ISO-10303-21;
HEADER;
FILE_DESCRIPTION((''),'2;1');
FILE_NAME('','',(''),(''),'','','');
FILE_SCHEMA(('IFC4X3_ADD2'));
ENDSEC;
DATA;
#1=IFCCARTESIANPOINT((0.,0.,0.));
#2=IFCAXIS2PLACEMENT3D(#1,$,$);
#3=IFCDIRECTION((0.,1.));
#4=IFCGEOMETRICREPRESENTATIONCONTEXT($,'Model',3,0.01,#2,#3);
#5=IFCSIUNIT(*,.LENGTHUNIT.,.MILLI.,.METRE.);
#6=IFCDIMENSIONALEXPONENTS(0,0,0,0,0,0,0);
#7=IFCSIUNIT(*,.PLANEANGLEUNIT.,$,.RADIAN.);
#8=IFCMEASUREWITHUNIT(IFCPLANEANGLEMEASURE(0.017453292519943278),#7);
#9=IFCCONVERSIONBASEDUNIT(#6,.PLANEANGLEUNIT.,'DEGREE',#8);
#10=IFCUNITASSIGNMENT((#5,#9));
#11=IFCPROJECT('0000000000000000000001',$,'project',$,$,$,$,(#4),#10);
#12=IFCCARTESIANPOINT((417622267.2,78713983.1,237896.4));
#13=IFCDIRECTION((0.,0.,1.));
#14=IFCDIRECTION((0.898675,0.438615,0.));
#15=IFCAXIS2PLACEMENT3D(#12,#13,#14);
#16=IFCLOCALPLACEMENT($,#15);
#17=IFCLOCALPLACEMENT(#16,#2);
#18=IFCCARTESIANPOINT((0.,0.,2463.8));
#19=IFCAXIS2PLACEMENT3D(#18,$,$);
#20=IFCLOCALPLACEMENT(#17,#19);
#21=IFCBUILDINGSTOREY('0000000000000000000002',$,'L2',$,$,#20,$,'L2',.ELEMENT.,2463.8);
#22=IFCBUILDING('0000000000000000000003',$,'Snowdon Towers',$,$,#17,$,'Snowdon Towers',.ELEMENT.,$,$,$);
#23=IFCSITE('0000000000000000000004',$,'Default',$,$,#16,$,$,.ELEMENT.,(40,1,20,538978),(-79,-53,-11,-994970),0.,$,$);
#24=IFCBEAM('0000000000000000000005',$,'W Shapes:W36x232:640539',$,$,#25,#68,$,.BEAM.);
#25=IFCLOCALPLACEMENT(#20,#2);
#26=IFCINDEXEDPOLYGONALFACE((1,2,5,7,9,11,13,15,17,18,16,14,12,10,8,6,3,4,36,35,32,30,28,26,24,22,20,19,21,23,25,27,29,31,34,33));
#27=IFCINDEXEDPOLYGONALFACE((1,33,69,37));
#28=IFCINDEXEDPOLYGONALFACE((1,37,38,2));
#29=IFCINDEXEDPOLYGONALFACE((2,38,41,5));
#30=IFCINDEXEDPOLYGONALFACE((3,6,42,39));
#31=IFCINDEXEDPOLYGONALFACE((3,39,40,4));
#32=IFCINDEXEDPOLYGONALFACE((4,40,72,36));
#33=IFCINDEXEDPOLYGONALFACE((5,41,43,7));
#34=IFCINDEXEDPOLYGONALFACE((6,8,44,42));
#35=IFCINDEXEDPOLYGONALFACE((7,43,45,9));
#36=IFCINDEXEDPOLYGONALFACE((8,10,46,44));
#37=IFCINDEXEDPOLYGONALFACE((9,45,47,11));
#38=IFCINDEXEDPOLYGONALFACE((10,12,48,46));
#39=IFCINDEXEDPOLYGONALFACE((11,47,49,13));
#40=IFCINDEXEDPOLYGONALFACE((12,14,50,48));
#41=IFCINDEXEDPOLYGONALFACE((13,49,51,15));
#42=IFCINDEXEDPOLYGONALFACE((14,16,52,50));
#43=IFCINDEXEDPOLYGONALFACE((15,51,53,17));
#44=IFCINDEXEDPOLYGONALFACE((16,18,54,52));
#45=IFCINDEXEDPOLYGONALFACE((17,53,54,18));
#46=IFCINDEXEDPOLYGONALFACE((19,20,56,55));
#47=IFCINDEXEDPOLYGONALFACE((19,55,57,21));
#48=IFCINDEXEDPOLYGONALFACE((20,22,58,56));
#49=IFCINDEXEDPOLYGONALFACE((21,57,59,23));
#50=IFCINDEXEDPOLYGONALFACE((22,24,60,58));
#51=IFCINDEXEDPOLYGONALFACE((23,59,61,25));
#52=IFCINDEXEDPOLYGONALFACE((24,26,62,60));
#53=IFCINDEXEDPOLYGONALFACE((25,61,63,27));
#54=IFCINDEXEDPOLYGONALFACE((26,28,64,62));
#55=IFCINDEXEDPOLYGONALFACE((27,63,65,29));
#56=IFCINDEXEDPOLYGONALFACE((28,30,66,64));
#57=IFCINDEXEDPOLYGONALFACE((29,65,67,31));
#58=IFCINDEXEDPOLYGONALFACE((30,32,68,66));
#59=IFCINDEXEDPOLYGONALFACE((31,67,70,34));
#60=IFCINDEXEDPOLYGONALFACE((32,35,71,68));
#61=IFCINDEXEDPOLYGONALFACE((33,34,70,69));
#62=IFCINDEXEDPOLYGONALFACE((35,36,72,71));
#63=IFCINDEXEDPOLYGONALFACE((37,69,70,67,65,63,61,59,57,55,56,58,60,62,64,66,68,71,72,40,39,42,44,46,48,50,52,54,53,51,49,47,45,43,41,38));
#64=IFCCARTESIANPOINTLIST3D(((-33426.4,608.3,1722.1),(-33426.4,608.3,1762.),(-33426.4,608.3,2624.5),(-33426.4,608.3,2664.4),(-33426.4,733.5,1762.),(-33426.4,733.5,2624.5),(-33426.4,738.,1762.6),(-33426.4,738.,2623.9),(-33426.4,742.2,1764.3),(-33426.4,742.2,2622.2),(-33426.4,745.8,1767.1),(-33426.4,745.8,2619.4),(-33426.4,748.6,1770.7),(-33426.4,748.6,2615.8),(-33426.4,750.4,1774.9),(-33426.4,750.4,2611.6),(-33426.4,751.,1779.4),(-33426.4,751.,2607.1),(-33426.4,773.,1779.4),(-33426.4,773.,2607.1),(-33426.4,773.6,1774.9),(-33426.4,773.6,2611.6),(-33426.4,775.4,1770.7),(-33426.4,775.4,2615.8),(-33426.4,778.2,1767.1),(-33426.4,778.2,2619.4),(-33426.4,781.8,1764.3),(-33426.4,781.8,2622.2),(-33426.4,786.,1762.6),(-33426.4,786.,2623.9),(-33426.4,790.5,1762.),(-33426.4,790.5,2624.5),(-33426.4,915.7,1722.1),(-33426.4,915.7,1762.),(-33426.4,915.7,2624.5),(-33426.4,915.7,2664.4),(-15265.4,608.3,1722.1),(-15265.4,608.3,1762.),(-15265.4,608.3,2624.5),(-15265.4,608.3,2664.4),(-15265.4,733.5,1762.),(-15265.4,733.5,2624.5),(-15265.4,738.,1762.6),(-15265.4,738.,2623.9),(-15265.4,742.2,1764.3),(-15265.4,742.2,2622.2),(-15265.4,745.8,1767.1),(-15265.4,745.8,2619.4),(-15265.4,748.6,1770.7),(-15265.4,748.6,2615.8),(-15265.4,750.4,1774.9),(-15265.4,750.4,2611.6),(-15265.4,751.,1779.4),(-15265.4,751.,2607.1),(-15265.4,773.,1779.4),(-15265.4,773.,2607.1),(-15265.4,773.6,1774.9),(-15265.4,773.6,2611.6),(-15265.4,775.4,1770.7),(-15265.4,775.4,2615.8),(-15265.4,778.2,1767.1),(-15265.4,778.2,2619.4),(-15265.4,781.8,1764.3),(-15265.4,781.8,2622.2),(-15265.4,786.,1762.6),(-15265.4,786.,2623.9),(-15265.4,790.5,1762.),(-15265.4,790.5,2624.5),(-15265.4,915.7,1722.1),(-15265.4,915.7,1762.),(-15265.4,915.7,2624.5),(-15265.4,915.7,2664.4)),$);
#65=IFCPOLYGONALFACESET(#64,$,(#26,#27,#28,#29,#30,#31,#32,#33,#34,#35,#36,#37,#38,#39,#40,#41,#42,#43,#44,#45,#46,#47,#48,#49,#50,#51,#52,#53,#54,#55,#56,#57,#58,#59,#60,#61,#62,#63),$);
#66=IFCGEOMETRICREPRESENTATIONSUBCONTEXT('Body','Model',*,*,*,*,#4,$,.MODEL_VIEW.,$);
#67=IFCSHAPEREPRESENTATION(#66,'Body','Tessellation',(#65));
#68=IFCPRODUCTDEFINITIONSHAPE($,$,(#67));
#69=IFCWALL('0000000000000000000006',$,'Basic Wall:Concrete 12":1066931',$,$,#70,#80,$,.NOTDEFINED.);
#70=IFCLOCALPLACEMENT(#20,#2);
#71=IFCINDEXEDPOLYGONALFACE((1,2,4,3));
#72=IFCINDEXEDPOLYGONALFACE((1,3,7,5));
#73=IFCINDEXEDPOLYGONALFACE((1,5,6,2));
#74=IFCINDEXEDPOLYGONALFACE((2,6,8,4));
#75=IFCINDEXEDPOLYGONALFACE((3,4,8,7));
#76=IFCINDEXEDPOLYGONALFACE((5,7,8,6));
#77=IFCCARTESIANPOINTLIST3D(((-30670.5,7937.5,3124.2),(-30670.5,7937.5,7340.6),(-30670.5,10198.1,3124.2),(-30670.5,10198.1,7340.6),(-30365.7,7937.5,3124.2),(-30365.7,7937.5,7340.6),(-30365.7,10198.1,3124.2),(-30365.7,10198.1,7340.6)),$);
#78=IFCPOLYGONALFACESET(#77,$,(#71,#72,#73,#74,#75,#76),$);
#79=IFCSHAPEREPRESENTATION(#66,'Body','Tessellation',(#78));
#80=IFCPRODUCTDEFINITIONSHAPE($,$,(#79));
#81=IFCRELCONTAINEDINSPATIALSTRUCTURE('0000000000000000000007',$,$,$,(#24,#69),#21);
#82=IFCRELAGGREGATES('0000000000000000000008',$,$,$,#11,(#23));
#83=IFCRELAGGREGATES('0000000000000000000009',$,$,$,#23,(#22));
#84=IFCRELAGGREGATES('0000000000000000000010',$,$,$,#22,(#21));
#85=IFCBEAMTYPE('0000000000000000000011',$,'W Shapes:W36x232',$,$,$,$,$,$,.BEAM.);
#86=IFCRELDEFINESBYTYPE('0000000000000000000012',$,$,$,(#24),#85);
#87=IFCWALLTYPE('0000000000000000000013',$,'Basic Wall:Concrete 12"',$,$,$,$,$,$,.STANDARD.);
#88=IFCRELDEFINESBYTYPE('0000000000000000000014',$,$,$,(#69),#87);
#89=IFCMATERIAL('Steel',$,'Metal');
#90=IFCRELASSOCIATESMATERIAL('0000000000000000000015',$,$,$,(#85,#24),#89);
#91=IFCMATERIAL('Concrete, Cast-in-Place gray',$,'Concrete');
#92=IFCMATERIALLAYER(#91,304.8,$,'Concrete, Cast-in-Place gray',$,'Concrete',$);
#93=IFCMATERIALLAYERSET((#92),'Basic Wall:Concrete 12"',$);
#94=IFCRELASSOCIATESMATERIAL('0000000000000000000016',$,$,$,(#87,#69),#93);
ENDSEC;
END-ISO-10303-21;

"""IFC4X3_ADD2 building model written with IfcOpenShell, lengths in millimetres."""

from ifc_helpers import new_model, entity, si_unit, converted_unit, direction, frame, frame_2d, origin, place, context, subcontext, project, spatial, polyline, circle_curve, parameter, trimmed, segment, composite_curve, rectangle, outline, extrude, source, transform, mapped, material, layer, layer_set, material_profile, profile_set, profile_usage, type_object, type_shapes, element, save


model = new_model("IFC4X3_ADD2")

# Units and contexts
model_context = context("Model", 3, precision=0.01, world=origin(), true_north=direction((0.0, 1.0)))
body_context = subcontext(model_context, "Body", "Model", "MODEL_VIEW")
ifc_project = project(units=[si_unit("LENGTHUNIT", "METRE", prefix="MILLI"), converted_unit("PLANEANGLEUNIT", "DEGREE", entity("IfcPlaneAngleMeasure", 0.017453292519943278), si_unit("PLANEANGLEUNIT", "RADIAN"), dimensions=[0, 0, 0, 0, 0, 0, 0])], contexts=[model_context])

# Site, building, storey
site_placement = place(None, frame((417622267.2, 78713983.1, 237896.4), z_axis=(0.0, 0.0, 1.0), x_axis=(0.898675, 0.438615, 0.0)))
site = spatial("IfcSite", under=ifc_project, at=site_placement, Name="Default", CompositionType="ELEMENT", RefLatitude=(40, 1, 20, 538978), RefLongitude=(-79, -53, -11, -994970), RefElevation=0.0)
building_placement = place(site_placement, origin())
building = spatial("IfcBuilding", under=site, at=building_placement, Name="Snowdon Towers", LongName="Snowdon Towers", CompositionType="ELEMENT")
storey_placement = place(building_placement, frame((0.0, 0.0, 2463.8)))
storey = spatial("IfcBuildingStorey", under=building, at=storey_placement, Name="L2", LongName="L2", CompositionType="ELEMENT", Elevation=2463.8)

# Beam
ifc_material_1 = material(Name="Steel", Category="Metal")
ifc_material_profile_1 = material_profile(ifc_material_1, outline(composite_curve([segment(polyline([(-153.7, -431.3), (-153.7, -471.2)]), True, "CONTINUOUS"), segment(polyline([(-153.7, -471.2), (153.7, -471.2)]), True, "CONTINUOUS"), segment(polyline([(153.7, -471.2), (153.7, -431.3)]), True, "CONTINUOUS"), segment(polyline([(153.7, -431.3), (28.5, -431.3)]), True, "CONTINUOUS"), segment(trimmed(circle_curve(frame_2d((28.5, -413.8), x_axis=(1.0, 0.0)), 17.5), [parameter(180.0)], [parameter(270.0)], True, "PARAMETER"), False, "CONTINUOUS"), segment(polyline([(11.0, -413.8), (11.0, 413.8)]), True, "CONTINUOUS"), segment(trimmed(circle_curve(frame_2d((28.5, 413.8), x_axis=(1.0, 0.0)), 17.5), [parameter(90.0)], [parameter(180.0)], True, "PARAMETER"), False, "CONTINUOUS"), segment(polyline([(28.5, 431.3), (153.7, 431.3)]), True, "CONTINUOUS"), segment(polyline([(153.7, 431.3), (153.7, 471.2)]), True, "CONTINUOUS"), segment(polyline([(153.7, 471.2), (-153.7, 471.2)]), True, "CONTINUOUS"), segment(polyline([(-153.7, 471.2), (-153.7, 431.3)]), True, "CONTINUOUS"), segment(polyline([(-153.7, 431.3), (-28.5, 431.3)]), True, "CONTINUOUS"), segment(trimmed(circle_curve(frame_2d((-28.5, 413.8), x_axis=(1.0, 0.0)), 17.5), [parameter(360.0)], [parameter(90.0)], True, "PARAMETER"), False, "CONTINUOUS"), segment(polyline([(-11.0, 413.8), (-11.0, -413.8)]), True, "CONTINUOUS"), segment(trimmed(circle_curve(frame_2d((-28.5, -413.8), x_axis=(1.0, 0.0)), 17.5), [parameter(270.0)], [parameter(360.0)], True, "PARAMETER"), False, "CONTINUOUS"), segment(polyline([(-28.5, -431.3), (-153.7, -431.3)]), True, "CONTINUOUS")], self_intersect=False)), Name="W36x232")
ifc_profile_set_1 = profile_set([ifc_material_profile_1], Name="W36x232")
ifc_profile_usage_1 = profile_usage(ifc_profile_set_1, cardinal=8)
beam_type_1 = type_object("IfcBeamType", Name="W Shapes:W36x232", PredefinedType="BEAM", material=ifc_profile_set_1)
shared_shape_1 = source(origin(), body_context, "Body", "SweptSolid", [
    extrude(outline(composite_curve([segment(polyline([(-153.7, -431.3), (-153.7, -471.2)]), True, "CONTINUOUS"), segment(polyline([(-153.7, -471.2), (153.7, -471.2)]), True, "CONTINUOUS"), segment(polyline([(153.7, -471.2), (153.7, -431.3)]), True, "CONTINUOUS"), segment(polyline([(153.7, -431.3), (28.5, -431.3)]), True, "CONTINUOUS"), segment(trimmed(circle_curve(frame_2d((28.5, -413.8), x_axis=(1.0, 0.0)), 17.5), [parameter(180.0)], [parameter(270.0)], True, "PARAMETER"), False, "CONTINUOUS"), segment(polyline([(11.0, -413.8), (11.0, 413.8)]), True, "CONTINUOUS"), segment(trimmed(circle_curve(frame_2d((28.5, 413.8), x_axis=(1.0, 0.0)), 17.5), [parameter(90.0)], [parameter(180.0)], True, "PARAMETER"), False, "CONTINUOUS"), segment(polyline([(28.5, 431.3), (153.7, 431.3)]), True, "CONTINUOUS"), segment(polyline([(153.7, 431.3), (153.7, 471.2)]), True, "CONTINUOUS"), segment(polyline([(153.7, 471.2), (-153.7, 471.2)]), True, "CONTINUOUS"), segment(polyline([(-153.7, 471.2), (-153.7, 431.3)]), True, "CONTINUOUS"), segment(polyline([(-153.7, 431.3), (-28.5, 431.3)]), True, "CONTINUOUS"), segment(trimmed(circle_curve(frame_2d((-28.5, 413.8), x_axis=(1.0, 0.0)), 17.5), [parameter(360.0)], [parameter(90.0)], True, "PARAMETER"), False, "CONTINUOUS"), segment(polyline([(-11.0, 413.8), (-11.0, -413.8)]), True, "CONTINUOUS"), segment(trimmed(circle_curve(frame_2d((-28.5, -413.8), x_axis=(1.0, 0.0)), 17.5), [parameter(270.0)], [parameter(360.0)], True, "PARAMETER"), False, "CONTINUOUS"), segment(polyline([(-28.5, -431.3), (-153.7, -431.3)]), True, "CONTINUOUS")], self_intersect=False)), frame((-9004.3, 0.0, 0.0), z_axis=(-1.0, 0.0, 0.0), x_axis=(0.0, -1.0, 0.0)), (0.0, 0.0, -1.0), 18161.0),
])
type_shapes(beam_type_1, [shared_shape_1])
beam_1_placement = place(storey_placement, frame((-24422.1, 762.0, 2193.3)))
element("IfcBeam", 1, at=beam_1_placement, inside=storey, type_object=beam_type_1, material=ifc_profile_usage_1, Name="W Shapes:W36x232:640539", PredefinedType="BEAM", context=body_context, shape_type="MappedRepresentation", body=[
    mapped(shared_shape_1, transform((0.0, 0.0, 0.0), scale=1.0)),
])

# Wall
ifc_material_2 = material(Name="Concrete, Cast-in-Place gray", Category="Concrete")
ifc_layer = layer(ifc_material_2, 304.8, Name="Concrete, Cast-in-Place gray", Category="Concrete")
ifc_layer_set = layer_set([ifc_layer], Name="Basic Wall:Concrete 12\"")
wall_type = type_object("IfcWallType", Name="Basic Wall:Concrete 12\"", PredefinedType="STANDARD", material=ifc_layer_set)
wall_placement = place(storey_placement, frame((-30518.1, 7937.5, 3124.2), z_axis=(0.0, 0.0, 1.0), x_axis=(0.0, 1.0, 0.0)))
element("IfcWall", 2, at=wall_placement, inside=storey, type_object=wall_type, material=ifc_layer_set, Name="Basic Wall:Concrete 12\":1066931", PredefinedType="NOTDEFINED", context=body_context, shape_type="SweptSolid", body=[
    extrude(rectangle(XDim=2260.6, YDim=304.8, at=frame_2d((1130.3, 0.0), x_axis=(-1.0, 0.0))), origin(), (0.0, 0.0, 1.0), 4216.4),
])

save(model, "model.ifc")
